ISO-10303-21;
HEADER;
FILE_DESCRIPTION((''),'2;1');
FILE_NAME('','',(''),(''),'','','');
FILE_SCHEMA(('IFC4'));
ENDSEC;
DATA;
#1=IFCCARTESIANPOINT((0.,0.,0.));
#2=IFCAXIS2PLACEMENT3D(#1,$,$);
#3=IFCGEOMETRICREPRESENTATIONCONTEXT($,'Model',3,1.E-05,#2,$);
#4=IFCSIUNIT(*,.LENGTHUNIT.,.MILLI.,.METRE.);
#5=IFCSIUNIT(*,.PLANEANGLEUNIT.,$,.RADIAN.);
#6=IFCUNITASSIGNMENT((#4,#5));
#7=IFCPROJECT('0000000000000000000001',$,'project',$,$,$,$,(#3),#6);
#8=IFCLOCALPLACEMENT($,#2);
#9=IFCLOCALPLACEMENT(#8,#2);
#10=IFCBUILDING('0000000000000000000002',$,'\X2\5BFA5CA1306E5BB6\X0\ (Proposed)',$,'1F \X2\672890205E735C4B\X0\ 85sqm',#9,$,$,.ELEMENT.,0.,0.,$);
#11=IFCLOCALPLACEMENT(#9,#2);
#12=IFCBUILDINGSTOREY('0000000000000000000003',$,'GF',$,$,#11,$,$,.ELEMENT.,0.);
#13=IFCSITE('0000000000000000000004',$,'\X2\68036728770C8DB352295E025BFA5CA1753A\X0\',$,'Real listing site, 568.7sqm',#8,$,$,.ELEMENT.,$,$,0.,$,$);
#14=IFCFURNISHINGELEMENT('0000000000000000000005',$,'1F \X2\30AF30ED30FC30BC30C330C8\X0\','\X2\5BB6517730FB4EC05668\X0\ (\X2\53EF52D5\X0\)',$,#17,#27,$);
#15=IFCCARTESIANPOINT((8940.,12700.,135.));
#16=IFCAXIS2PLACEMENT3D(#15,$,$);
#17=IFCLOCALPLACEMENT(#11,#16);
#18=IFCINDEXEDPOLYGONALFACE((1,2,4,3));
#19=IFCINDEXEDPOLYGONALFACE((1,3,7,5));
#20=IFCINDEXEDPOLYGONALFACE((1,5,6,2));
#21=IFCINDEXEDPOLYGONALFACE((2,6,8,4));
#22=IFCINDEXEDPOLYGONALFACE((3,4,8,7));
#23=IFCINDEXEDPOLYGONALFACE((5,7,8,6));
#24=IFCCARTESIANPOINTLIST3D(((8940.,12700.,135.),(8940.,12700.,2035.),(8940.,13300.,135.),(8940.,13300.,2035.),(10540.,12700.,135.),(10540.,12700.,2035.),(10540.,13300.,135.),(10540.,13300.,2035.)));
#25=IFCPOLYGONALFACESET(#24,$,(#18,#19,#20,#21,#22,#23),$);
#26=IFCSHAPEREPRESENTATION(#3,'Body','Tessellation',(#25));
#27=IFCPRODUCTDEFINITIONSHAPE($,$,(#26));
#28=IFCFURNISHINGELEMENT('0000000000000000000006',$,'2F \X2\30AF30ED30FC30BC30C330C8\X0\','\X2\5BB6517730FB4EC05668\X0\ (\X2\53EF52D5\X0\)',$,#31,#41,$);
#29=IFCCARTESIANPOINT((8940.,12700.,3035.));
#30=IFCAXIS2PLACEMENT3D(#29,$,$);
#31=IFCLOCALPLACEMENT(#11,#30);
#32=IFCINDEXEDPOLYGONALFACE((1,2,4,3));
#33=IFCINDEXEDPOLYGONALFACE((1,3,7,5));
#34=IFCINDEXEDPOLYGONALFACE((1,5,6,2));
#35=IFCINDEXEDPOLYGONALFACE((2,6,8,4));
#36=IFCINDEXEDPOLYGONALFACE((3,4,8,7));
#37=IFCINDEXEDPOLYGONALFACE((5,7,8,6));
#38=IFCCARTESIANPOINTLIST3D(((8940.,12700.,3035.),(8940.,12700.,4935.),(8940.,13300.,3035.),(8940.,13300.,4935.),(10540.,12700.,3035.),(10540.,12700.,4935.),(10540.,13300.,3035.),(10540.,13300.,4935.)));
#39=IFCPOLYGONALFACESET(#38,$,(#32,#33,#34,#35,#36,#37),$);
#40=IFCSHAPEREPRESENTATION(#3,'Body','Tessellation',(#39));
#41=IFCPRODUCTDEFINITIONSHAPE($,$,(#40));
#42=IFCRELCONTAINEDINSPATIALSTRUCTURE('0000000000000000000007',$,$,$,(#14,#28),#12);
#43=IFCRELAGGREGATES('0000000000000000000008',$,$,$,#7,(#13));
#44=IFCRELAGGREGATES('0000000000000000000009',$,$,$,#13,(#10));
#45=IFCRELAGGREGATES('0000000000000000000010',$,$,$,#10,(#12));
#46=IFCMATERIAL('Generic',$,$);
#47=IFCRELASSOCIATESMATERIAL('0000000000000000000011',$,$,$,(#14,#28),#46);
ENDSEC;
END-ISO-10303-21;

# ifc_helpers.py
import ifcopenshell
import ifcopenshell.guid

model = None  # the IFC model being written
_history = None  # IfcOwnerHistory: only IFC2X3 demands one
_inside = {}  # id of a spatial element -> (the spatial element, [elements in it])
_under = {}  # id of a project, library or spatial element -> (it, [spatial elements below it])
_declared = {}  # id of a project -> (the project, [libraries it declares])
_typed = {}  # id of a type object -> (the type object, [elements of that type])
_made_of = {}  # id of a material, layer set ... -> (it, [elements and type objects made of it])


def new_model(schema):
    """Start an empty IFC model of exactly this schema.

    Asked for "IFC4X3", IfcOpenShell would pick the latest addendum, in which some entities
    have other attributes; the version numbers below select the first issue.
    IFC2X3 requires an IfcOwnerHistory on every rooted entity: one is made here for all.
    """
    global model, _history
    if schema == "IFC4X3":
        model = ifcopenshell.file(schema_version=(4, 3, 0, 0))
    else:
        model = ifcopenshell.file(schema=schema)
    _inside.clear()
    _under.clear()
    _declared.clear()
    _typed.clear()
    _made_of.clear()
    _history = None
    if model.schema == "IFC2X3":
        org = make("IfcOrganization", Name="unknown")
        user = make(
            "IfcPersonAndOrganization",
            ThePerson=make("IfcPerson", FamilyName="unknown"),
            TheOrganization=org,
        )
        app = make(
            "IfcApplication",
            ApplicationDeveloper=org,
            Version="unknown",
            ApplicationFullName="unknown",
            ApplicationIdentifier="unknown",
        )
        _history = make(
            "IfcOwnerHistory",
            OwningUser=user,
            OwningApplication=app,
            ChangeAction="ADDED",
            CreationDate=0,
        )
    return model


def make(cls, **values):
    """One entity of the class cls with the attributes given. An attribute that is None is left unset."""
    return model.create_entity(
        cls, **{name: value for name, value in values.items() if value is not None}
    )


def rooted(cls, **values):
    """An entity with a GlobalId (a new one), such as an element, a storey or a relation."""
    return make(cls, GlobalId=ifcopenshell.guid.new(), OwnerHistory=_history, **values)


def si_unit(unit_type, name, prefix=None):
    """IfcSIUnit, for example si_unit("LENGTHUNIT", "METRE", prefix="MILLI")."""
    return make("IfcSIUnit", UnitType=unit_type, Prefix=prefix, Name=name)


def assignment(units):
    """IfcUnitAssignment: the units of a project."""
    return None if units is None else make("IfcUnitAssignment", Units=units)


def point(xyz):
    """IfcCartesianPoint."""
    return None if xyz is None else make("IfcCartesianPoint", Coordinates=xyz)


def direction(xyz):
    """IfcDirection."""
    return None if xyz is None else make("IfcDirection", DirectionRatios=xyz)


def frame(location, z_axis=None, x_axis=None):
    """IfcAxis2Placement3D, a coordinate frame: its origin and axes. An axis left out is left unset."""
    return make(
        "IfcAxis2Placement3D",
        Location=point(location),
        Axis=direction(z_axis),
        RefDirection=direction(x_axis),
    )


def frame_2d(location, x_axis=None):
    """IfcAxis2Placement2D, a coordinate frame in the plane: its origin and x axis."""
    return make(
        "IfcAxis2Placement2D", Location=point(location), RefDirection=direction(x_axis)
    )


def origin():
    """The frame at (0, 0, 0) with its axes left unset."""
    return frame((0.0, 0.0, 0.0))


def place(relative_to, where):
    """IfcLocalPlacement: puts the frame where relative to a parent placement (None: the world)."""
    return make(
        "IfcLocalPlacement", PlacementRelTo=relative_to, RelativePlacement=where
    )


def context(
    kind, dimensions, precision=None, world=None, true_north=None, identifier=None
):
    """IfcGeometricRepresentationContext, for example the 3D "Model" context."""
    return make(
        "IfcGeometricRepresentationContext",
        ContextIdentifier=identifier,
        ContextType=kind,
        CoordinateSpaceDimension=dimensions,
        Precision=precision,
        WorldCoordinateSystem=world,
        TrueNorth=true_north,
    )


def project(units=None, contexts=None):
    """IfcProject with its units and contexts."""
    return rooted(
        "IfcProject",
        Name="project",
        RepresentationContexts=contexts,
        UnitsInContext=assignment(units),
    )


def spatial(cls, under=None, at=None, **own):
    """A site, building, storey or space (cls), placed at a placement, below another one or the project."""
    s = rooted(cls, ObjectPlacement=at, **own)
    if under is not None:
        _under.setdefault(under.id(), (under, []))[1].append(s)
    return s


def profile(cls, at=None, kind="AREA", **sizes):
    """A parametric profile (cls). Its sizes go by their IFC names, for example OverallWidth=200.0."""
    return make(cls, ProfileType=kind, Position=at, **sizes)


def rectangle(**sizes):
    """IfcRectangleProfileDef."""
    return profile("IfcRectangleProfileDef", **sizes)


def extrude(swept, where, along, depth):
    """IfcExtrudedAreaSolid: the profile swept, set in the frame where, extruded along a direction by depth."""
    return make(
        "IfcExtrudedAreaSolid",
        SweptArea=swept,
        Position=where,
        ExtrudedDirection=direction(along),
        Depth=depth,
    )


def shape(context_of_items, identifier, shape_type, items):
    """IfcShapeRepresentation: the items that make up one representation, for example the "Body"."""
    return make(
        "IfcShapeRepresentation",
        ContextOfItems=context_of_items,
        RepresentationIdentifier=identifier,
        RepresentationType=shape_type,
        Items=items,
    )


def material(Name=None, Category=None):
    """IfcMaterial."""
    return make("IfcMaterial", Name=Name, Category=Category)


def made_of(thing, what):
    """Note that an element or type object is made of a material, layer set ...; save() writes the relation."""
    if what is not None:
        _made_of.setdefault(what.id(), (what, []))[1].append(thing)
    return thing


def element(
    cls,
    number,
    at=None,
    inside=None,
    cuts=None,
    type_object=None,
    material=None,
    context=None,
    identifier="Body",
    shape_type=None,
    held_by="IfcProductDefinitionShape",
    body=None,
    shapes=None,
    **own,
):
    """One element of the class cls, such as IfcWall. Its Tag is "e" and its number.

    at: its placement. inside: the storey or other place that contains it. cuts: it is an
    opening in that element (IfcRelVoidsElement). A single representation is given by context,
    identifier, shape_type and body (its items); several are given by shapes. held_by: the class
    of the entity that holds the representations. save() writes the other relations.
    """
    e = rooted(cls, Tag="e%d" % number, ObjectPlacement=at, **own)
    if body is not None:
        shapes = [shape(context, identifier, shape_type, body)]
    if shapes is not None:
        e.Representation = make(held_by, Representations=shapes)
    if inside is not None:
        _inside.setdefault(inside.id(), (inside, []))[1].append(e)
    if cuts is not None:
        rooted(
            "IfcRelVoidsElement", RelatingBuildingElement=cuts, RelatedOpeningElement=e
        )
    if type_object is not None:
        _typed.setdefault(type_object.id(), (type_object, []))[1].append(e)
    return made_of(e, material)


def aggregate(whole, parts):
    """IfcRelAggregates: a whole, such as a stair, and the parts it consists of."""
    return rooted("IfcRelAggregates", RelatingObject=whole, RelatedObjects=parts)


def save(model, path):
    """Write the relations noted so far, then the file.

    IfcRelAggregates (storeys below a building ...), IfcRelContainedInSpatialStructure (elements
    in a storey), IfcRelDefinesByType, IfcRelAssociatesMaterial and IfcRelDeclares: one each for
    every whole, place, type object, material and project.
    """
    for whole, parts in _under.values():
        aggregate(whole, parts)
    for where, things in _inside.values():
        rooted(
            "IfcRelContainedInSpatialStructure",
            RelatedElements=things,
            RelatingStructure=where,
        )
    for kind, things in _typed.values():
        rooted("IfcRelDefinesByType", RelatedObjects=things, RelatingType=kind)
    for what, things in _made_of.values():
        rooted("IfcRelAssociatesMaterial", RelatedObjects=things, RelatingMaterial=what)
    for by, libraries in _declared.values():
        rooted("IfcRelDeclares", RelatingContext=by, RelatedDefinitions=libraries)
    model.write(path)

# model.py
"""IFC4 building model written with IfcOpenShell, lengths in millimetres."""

from ifc_helpers import new_model, si_unit, frame, frame_2d, origin, place, context, project, spatial, rectangle, extrude, material, element, save


model = new_model("IFC4")

# Units and contexts
model_context = context("Model", 3, precision=1e-05, world=origin())
ifc_project = project(units=[si_unit("LENGTHUNIT", "METRE", prefix="MILLI"), si_unit("PLANEANGLEUNIT", "RADIAN")], contexts=[model_context])

# Site, building, storey
site_placement = place(None, origin())
site = spatial("IfcSite", under=ifc_project, at=site_placement, Name="栃木県足利市寺岡町", ObjectType="Real listing site, 568.7sqm", CompositionType="ELEMENT", RefElevation=0.0)
building_placement = place(site_placement, origin())
building = spatial("IfcBuilding", under=site, at=building_placement, Name="寺岡の家 (Proposed)", ObjectType="1F 木造平屋 85sqm", CompositionType="ELEMENT", ElevationOfRefHeight=0.0, ElevationOfTerrain=0.0)
storey_placement = place(building_placement, origin())
storey = spatial("IfcBuildingStorey", under=building, at=storey_placement, Name="GF", CompositionType="ELEMENT", Elevation=0.0)

# Shared definitions
ifc_material_1 = material(Name="Generic")

# Furnishing elements
furnishing_1_placement = place(storey_placement, frame((8940.0, 12700.0, 135.0)))
element("IfcFurnishingElement", 1, at=furnishing_1_placement, inside=storey, material=ifc_material_1, Name="1F クローゼット", Description="家具・什器 (可動)", context=model_context, shape_type="SweptSolid", body=[
    extrude(rectangle(XDim=1600.0, YDim=600.0, at=frame_2d((800.0, 300.0))), frame((8940.0, 12700.0, 135.0)), (0.0, 0.0, 1.0), 1900.0),
])
furnishing_2_placement = place(storey_placement, frame((8940.0, 12700.0, 3035.0)))
element("IfcFurnishingElement", 2, at=furnishing_2_placement, inside=storey, material=ifc_material_1, Name="2F クローゼット", Description="家具・什器 (可動)", context=model_context, shape_type="SweptSolid", body=[
    extrude(rectangle(XDim=1600.0, YDim=600.0, at=frame_2d((800.0, 300.0))), frame((8940.0, 12700.0, 3035.0)), (0.0, 0.0, 1.0), 1900.0),
])

save(model, "model.ifc")
